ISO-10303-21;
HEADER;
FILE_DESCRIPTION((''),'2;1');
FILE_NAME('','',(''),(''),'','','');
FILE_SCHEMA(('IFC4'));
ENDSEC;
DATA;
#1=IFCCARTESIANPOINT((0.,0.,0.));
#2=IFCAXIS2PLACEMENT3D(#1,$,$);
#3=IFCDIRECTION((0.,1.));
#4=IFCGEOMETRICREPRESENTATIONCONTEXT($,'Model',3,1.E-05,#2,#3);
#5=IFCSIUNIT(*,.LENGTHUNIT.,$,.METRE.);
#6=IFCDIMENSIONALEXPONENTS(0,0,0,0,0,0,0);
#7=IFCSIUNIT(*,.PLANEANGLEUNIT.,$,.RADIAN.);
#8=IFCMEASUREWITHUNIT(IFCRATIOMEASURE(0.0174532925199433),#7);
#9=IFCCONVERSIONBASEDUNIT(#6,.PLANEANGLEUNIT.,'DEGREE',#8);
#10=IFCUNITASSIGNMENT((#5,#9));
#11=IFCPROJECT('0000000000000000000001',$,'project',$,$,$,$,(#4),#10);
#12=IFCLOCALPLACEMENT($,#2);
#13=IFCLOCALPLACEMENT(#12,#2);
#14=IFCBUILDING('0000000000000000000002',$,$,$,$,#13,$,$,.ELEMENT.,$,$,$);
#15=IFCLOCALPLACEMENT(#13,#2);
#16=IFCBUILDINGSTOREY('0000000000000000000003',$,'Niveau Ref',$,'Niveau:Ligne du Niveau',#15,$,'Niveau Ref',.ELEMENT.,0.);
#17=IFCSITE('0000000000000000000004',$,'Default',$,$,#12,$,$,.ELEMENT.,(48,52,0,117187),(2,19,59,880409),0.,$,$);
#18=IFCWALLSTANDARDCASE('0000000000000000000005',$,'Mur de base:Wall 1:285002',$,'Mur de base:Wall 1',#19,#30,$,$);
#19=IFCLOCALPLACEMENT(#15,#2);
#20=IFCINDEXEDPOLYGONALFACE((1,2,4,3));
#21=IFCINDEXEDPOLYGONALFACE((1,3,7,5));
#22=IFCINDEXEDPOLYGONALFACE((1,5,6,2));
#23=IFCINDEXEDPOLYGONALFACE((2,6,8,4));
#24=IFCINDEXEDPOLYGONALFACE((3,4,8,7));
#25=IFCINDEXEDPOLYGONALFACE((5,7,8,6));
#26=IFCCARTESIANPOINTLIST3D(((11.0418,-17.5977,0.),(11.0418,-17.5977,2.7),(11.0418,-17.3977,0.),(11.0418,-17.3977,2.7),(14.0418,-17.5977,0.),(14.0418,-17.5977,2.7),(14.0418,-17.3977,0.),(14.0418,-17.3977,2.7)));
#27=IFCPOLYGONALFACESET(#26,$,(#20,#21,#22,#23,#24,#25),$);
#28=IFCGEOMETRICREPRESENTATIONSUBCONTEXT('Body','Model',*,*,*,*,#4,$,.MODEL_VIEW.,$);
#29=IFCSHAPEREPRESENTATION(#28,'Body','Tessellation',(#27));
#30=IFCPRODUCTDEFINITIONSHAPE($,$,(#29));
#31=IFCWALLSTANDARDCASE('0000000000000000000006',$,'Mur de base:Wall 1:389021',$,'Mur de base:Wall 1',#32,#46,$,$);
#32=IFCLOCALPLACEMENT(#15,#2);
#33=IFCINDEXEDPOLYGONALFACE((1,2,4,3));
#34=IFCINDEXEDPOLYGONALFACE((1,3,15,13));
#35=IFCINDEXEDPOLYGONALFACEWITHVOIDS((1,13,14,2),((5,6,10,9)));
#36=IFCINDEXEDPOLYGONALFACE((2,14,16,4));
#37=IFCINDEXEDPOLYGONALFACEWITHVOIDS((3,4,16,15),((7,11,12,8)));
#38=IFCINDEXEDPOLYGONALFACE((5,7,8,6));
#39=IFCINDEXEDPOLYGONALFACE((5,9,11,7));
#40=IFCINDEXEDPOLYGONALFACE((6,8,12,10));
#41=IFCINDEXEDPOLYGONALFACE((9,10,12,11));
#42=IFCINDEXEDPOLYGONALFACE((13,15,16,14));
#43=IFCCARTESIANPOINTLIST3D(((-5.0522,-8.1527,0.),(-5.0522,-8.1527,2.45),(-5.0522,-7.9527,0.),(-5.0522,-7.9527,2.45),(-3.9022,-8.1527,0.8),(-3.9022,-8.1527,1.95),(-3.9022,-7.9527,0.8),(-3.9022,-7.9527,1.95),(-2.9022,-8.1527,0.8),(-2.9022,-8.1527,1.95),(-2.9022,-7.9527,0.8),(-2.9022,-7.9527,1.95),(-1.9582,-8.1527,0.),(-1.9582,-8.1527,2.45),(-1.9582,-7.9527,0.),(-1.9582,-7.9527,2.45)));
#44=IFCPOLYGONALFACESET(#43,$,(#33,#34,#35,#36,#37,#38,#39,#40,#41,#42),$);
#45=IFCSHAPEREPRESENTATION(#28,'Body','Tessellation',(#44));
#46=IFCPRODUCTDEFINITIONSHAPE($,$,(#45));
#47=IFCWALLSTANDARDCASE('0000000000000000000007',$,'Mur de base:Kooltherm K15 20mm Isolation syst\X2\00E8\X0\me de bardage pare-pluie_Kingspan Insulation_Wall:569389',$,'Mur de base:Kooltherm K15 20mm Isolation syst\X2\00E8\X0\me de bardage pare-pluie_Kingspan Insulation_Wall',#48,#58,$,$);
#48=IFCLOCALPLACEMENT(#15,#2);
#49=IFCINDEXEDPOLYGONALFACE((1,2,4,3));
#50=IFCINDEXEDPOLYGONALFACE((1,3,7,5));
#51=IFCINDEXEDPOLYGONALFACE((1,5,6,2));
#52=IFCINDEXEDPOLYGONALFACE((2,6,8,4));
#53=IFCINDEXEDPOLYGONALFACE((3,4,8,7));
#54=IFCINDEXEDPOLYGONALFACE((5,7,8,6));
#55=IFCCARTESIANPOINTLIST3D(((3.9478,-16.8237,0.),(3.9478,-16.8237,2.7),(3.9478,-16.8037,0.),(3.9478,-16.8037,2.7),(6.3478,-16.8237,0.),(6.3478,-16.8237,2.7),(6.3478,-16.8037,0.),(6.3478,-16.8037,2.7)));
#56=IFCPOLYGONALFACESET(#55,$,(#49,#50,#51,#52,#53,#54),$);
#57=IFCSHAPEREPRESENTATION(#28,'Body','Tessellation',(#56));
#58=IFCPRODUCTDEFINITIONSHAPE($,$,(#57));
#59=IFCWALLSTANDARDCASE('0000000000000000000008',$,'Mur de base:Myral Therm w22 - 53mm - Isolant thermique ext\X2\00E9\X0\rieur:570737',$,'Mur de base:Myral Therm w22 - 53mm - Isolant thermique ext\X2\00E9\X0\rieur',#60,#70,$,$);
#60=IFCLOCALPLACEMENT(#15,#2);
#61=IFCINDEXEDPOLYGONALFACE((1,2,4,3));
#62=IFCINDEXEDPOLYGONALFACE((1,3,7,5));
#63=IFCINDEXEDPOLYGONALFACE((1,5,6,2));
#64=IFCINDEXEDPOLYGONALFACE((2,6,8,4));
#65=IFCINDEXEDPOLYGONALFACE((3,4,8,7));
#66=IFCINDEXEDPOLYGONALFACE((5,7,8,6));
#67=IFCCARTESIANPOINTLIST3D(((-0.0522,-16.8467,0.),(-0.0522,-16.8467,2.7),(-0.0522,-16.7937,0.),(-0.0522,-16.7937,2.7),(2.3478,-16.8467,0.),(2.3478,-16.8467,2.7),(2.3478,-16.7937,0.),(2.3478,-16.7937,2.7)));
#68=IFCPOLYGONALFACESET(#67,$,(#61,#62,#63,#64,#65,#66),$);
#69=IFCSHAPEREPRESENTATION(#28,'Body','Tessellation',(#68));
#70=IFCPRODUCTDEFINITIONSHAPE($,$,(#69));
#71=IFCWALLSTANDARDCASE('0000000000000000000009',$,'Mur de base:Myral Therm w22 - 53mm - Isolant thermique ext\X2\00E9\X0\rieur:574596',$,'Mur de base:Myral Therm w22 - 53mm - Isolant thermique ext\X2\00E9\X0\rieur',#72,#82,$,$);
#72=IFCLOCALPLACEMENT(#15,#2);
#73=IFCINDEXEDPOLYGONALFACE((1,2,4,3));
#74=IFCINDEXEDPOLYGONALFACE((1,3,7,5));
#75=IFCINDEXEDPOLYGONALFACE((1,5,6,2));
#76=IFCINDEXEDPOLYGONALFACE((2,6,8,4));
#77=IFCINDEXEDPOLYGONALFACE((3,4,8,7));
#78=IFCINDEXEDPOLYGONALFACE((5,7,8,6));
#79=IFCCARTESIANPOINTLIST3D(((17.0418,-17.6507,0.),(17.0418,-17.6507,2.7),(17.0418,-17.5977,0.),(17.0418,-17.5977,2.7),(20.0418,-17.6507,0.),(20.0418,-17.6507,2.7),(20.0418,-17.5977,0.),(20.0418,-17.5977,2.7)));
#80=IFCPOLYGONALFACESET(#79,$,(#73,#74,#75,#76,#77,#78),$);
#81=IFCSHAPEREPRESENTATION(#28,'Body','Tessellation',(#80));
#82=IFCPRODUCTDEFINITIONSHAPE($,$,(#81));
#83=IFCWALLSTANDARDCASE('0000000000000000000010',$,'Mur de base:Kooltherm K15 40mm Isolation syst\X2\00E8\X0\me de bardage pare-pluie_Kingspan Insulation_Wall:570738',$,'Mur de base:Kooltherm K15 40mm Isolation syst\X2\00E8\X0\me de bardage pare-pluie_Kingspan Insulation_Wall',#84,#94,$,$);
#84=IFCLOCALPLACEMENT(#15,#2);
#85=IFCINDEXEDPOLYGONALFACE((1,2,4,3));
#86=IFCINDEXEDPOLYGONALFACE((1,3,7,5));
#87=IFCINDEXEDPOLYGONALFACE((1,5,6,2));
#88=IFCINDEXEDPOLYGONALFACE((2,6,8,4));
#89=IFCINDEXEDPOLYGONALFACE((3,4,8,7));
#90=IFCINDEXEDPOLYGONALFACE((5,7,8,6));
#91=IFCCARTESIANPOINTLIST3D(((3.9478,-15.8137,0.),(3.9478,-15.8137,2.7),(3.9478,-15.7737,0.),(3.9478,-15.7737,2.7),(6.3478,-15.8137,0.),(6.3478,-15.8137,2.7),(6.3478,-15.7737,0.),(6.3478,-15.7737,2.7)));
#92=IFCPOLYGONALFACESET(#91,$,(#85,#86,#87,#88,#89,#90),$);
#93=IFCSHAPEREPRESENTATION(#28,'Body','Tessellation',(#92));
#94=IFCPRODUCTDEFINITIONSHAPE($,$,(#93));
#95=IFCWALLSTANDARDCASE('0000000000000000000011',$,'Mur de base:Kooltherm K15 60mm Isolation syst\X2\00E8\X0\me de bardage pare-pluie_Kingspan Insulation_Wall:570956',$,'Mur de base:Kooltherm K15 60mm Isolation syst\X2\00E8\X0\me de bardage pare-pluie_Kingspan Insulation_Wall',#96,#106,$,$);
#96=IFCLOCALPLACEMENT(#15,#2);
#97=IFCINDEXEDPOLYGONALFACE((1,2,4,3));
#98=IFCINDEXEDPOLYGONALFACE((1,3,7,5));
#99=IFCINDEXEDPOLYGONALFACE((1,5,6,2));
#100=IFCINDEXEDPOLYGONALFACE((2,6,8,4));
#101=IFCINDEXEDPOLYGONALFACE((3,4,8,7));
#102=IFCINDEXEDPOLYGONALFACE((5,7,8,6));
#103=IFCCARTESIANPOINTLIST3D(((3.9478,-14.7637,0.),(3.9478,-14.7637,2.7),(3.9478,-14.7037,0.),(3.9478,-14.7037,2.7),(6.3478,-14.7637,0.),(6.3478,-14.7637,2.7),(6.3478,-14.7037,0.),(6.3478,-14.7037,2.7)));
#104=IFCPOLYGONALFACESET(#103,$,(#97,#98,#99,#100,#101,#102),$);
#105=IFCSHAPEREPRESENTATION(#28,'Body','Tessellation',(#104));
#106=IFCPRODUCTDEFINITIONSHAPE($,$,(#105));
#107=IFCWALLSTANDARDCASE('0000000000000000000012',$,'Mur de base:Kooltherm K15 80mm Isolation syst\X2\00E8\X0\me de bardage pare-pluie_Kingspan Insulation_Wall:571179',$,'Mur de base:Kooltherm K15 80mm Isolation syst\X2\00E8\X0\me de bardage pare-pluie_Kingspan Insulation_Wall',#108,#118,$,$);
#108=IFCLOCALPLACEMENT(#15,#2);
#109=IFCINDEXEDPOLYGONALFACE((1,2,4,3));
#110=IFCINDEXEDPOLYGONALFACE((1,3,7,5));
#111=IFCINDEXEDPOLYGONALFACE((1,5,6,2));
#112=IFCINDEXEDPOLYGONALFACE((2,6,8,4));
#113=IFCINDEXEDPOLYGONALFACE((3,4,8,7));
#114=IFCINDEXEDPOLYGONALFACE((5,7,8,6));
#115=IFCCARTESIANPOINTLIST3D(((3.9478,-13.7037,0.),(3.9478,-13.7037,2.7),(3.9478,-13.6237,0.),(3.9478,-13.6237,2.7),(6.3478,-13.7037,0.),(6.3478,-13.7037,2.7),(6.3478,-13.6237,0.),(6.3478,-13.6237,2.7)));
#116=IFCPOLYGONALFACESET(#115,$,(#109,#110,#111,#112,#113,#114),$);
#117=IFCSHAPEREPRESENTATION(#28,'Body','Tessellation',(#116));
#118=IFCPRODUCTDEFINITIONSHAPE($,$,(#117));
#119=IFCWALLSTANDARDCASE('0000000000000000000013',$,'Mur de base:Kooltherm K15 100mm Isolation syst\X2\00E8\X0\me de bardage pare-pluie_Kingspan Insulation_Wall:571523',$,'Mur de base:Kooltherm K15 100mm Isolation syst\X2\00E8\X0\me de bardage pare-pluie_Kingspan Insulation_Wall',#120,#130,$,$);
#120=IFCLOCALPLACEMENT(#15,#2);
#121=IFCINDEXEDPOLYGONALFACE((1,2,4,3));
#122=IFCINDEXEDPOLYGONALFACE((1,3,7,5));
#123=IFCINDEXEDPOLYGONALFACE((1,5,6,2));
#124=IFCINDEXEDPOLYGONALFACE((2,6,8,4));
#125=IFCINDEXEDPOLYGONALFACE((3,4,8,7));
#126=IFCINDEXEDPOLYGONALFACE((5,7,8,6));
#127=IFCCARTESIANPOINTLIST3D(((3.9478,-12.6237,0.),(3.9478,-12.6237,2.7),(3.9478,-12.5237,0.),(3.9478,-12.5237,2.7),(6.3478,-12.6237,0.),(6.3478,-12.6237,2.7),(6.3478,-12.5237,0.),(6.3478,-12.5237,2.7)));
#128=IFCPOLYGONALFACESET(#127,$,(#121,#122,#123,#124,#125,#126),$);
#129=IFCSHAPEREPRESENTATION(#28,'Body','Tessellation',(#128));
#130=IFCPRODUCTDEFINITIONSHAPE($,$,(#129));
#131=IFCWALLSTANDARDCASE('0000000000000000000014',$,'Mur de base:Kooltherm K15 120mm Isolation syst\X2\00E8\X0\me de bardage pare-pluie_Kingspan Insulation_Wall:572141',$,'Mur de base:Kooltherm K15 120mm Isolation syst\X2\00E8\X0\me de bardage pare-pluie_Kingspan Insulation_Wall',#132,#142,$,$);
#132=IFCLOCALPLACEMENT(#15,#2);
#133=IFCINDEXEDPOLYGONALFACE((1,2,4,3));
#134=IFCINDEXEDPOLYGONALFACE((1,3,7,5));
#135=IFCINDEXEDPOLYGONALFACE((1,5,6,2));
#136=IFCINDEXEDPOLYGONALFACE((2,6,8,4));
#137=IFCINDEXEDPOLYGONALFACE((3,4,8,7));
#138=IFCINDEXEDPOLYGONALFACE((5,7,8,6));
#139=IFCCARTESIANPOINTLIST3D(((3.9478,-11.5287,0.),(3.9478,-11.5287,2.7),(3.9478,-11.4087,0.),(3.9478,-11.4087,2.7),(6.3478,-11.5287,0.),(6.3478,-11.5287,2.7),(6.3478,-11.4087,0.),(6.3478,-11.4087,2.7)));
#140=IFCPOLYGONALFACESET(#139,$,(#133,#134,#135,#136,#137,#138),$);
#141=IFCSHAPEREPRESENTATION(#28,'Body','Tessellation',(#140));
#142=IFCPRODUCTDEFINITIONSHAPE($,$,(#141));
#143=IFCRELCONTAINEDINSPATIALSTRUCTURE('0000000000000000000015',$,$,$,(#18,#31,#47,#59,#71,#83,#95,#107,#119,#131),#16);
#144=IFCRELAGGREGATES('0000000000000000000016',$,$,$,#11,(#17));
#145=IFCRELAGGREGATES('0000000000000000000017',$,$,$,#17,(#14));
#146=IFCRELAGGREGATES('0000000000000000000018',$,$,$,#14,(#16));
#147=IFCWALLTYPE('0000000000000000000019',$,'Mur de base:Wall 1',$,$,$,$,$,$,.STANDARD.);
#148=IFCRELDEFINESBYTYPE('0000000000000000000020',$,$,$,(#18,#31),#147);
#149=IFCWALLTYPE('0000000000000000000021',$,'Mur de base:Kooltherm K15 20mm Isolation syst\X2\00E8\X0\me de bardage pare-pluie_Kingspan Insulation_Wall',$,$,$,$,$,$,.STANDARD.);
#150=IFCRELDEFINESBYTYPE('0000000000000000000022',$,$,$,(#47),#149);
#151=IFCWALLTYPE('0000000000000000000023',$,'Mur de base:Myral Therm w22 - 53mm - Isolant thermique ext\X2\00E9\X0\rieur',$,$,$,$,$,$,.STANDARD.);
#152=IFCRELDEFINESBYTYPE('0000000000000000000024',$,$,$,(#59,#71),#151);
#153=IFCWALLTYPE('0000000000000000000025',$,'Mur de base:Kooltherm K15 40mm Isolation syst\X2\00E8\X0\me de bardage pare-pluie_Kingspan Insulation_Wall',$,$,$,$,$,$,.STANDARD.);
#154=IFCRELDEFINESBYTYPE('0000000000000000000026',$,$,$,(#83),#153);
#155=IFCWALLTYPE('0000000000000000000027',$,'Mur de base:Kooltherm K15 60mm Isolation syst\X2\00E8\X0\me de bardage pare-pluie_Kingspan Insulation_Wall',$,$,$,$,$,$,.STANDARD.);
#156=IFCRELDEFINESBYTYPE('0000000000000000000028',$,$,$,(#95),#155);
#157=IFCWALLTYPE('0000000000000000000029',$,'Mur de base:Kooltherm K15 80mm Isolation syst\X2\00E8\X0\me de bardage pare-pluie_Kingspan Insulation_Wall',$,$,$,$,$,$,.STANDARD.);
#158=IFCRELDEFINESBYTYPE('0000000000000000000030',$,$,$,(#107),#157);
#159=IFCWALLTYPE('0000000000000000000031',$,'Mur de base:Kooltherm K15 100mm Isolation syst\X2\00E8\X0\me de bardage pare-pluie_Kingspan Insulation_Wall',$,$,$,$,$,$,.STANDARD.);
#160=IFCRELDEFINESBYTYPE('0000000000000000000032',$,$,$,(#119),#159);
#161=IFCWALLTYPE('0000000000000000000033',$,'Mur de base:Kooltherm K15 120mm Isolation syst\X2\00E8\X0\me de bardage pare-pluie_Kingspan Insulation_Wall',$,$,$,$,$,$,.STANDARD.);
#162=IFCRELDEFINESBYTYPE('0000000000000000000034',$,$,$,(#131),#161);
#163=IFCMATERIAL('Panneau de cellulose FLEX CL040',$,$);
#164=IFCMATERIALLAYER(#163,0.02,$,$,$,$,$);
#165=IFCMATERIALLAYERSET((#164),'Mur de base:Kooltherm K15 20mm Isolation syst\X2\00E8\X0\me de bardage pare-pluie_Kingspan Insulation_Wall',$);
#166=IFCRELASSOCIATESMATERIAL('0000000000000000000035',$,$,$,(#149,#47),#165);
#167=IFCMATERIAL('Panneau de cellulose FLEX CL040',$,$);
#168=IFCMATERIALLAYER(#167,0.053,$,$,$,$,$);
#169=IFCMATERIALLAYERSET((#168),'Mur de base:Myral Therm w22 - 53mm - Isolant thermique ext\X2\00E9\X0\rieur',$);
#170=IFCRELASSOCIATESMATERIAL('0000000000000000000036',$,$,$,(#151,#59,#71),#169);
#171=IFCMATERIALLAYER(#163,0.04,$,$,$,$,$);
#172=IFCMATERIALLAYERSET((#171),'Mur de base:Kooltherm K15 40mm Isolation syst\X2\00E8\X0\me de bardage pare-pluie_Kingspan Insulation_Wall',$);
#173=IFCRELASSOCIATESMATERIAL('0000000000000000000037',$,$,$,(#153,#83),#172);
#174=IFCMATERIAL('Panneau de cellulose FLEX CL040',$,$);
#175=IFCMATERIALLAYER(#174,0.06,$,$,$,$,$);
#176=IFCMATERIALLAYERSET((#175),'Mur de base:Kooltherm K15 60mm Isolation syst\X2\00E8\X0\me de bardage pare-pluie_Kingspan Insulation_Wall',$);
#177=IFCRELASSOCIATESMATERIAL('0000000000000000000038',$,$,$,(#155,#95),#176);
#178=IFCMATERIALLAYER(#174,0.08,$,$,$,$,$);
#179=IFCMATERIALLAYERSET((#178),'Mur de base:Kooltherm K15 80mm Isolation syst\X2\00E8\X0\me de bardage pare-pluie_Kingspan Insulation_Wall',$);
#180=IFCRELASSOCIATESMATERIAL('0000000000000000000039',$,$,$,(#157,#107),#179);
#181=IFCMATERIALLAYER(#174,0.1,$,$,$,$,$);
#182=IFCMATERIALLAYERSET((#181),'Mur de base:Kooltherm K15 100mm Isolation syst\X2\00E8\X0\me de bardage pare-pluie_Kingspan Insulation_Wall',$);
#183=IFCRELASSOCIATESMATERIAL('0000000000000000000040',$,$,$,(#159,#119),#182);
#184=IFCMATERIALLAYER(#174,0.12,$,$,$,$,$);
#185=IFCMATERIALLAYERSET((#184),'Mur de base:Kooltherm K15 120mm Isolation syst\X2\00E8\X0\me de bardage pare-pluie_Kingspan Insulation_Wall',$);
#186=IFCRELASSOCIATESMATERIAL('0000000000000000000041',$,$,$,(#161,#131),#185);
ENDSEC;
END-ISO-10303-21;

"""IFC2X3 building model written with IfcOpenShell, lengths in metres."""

from ifc_helpers import new_model, entity, si_unit, converted_unit, direction, frame, frame_2d, origin, place, context, subcontext, project, spatial, rectangle, extrude, material, layer, layer_set, layer_usage, type_object, element, save


model = new_model("IFC2X3")

# Units and contexts
model_context = context("Model", 3, precision=1e-05, world=origin(), true_north=direction((0.0, 1.0)))
body_context = subcontext(model_context, "Body", "Model", "MODEL_VIEW")
ifc_project = project(units=[si_unit("LENGTHUNIT", "METRE"), converted_unit("PLANEANGLEUNIT", "DEGREE", entity("IfcRatioMeasure", 0.0174532925199433), si_unit("PLANEANGLEUNIT", "RADIAN"), dimensions=[0, 0, 0, 0, 0, 0, 0])], contexts=[model_context])

# Site, building, storey
site_placement = place(None, origin())
site = spatial("IfcSite", under=ifc_project, at=site_placement, Name="Default", CompositionType="ELEMENT", RefLatitude=(48, 52, 0, 117187), RefLongitude=(2, 19, 59, 880409), RefElevation=0.0)
building_placement = place(site_placement, origin())
building = spatial("IfcBuilding", under=site, at=building_placement, CompositionType="ELEMENT")
storey_placement = place(building_placement, origin())
storey = spatial("IfcBuildingStorey", under=building, at=storey_placement, Name="Niveau Ref", ObjectType="Niveau:Ligne du Niveau", LongName="Niveau Ref", CompositionType="ELEMENT", Elevation=0.0)

# Wall
wall_type_1 = type_object("IfcWallType", Name="Mur de base:Wall 1", PredefinedType="STANDARD")
for number, where, name in (
    (1, (11.0418, -17.4977, 0.0), "Mur de base:Wall 1:285002"),
):
    element("IfcWallStandardCase", number, at=place(storey_placement, frame(where)), inside=storey, type_object=wall_type_1, Name=name, ObjectType="Mur de base:Wall 1", context=body_context, shape_type="SweptSolid", body=[
        extrude(rectangle(XDim=3.0, YDim=0.2, at=frame_2d((1.5, 0.0), x_axis=(-1.0, 0.0))), origin(), (0.0, 0.0, 1.0), 2.7),
    ])

# Wall, opening
wall_1_placement = place(storey_placement, frame((-1.9582, -8.0527, 0.0), z_axis=(0.0, 0.0, 1.0), x_axis=(-1.0, 0.0, 0.0)))
wall_1 = element("IfcWallStandardCase", 2, at=wall_1_placement, inside=storey, type_object=wall_type_1, Name="Mur de base:Wall 1:389021", ObjectType="Mur de base:Wall 1", context=body_context, shape_type="SweptSolid", body=[
    extrude(rectangle(XDim=3.094, YDim=0.2, at=frame_2d((1.547, 0.0), x_axis=(-1.0, 0.0))), origin(), (0.0, 0.0, 1.0), 2.45),
])
opening_placement = place(wall_1_placement, frame((0.944, -0.1, 0.8)))
element("IfcOpeningElement", 3, at=opening_placement, cuts=wall_1, ObjectType="Opening", context=body_context, shape_type="SweptSolid", body=[
    extrude(rectangle(XDim=1.15, YDim=1.0, at=frame_2d((0.575, 0.5), x_axis=(1.0, 0.0))), frame((0.0, 0.0, 0.0), z_axis=(0.0, 1.0, 0.0), x_axis=(0.0, 0.0, 1.0)), (0.0, 0.0, 1.0), 0.2),
])

# Walls
ifc_material_1 = material(Name="Panneau de cellulose FLEX CL040")
ifc_layer_1 = layer(ifc_material_1, 0.02)
ifc_layer_set_1 = layer_set([ifc_layer_1], Name="Mur de base:Kooltherm K15 20mm Isolation système de bardage pare-pluie_Kingspan Insulation_Wall")
ifc_layer_usage_1 = layer_usage(ifc_layer_set_1, "AXIS2", "NEGATIVE", 0.01)
wall_type_2 = type_object("IfcWallType", Name="Mur de base:Kooltherm K15 20mm Isolation système de bardage pare-pluie_Kingspan Insulation_Wall", PredefinedType="STANDARD", material=ifc_layer_set_1)
wall_2_placement = place(storey_placement, frame((3.9478, -16.8137, 0.0)))
element("IfcWallStandardCase", 4, at=wall_2_placement, inside=storey, type_object=wall_type_2, material=ifc_layer_usage_1, Name="Mur de base:Kooltherm K15 20mm Isolation système de bardage pare-pluie_Kingspan Insulation_Wall:569389", ObjectType="Mur de base:Kooltherm K15 20mm Isolation système de bardage pare-pluie_Kingspan Insulation_Wall", context=body_context, shape_type="SweptSolid", body=[
    extrude(rectangle(XDim=2.4, YDim=0.02, at=frame_2d((1.2, 0.0), x_axis=(-1.0, 0.0))), origin(), (0.0, 0.0, 1.0), 2.7),
])
ifc_material_2 = material(Name="Panneau de cellulose FLEX CL040")
ifc_layer_2 = layer(ifc_material_2, 0.053)
ifc_layer_set_2 = layer_set([ifc_layer_2], Name="Mur de base:Myral Therm w22 - 53mm - Isolant thermique extérieur")
ifc_layer_usage_2 = layer_usage(ifc_layer_set_2, "AXIS2", "NEGATIVE", 0.0265)
wall_type_3 = type_object("IfcWallType", Name="Mur de base:Myral Therm w22 - 53mm - Isolant thermique extérieur", PredefinedType="STANDARD", material=ifc_layer_set_2)
wall_3_placement = place(storey_placement, frame((-0.0522, -16.8202, 0.0)))
element("IfcWallStandardCase", 5, at=wall_3_placement, inside=storey, type_object=wall_type_3, material=ifc_layer_usage_2, Name="Mur de base:Myral Therm w22 - 53mm - Isolant thermique extérieur:570737", ObjectType="Mur de base:Myral Therm w22 - 53mm - Isolant thermique extérieur", context=body_context, shape_type="SweptSolid", body=[
    extrude(rectangle(XDim=2.4, YDim=0.053, at=frame_2d((1.2, 0.0), x_axis=(-1.0, 0.0))), origin(), (0.0, 0.0, 1.0), 2.7),
])
ifc_layer_usage_3 = layer_usage(ifc_layer_set_2, "AXIS2", "NEGATIVE", 0.0265)
wall_4_placement = place(storey_placement, frame((17.0418, -17.6242, 0.0)))
element("IfcWallStandardCase", 6, at=wall_4_placement, inside=storey, type_object=wall_type_3, material=ifc_layer_usage_3, Name="Mur de base:Myral Therm w22 - 53mm - Isolant thermique extérieur:574596", ObjectType="Mur de base:Myral Therm w22 - 53mm - Isolant thermique extérieur", context=body_context, shape_type="SweptSolid", body=[
    extrude(rectangle(XDim=3.0, YDim=0.053, at=frame_2d((1.5, 0.0), x_axis=(-1.0, 0.0))), origin(), (0.0, 0.0, 1.0), 2.7),
])
ifc_layer_3 = layer(ifc_material_1, 0.04)
ifc_layer_set_3 = layer_set([ifc_layer_3], Name="Mur de base:Kooltherm K15 40mm Isolation système de bardage pare-pluie_Kingspan Insulation_Wall")
ifc_layer_usage_4 = layer_usage(ifc_layer_set_3, "AXIS2", "NEGATIVE", 0.02)
wall_type_4 = type_object("IfcWallType", Name="Mur de base:Kooltherm K15 40mm Isolation système de bardage pare-pluie_Kingspan Insulation_Wall", PredefinedType="STANDARD", material=ifc_layer_set_3)
wall_5_placement = place(storey_placement, frame((3.9478, -15.7937, 0.0)))
element("IfcWallStandardCase", 7, at=wall_5_placement, inside=storey, type_object=wall_type_4, material=ifc_layer_usage_4, Name="Mur de base:Kooltherm K15 40mm Isolation système de bardage pare-pluie_Kingspan Insulation_Wall:570738", ObjectType="Mur de base:Kooltherm K15 40mm Isolation système de bardage pare-pluie_Kingspan Insulation_Wall", context=body_context, shape_type="SweptSolid", body=[
    extrude(rectangle(XDim=2.4, YDim=0.04, at=frame_2d((1.2, 0.0), x_axis=(-1.0, 0.0))), origin(), (0.0, 0.0, 1.0), 2.7),
])
ifc_material_3 = material(Name="Panneau de cellulose FLEX CL040")
ifc_layer_4 = layer(ifc_material_3, 0.06)
ifc_layer_set_4 = layer_set([ifc_layer_4], Name="Mur de base:Kooltherm K15 60mm Isolation système de bardage pare-pluie_Kingspan Insulation_Wall")
ifc_layer_usage_5 = layer_usage(ifc_layer_set_4, "AXIS2", "NEGATIVE", 0.03)
wall_type_5 = type_object("IfcWallType", Name="Mur de base:Kooltherm K15 60mm Isolation système de bardage pare-pluie_Kingspan Insulation_Wall", PredefinedType="STANDARD", material=ifc_layer_set_4)
wall_6_placement = place(storey_placement, frame((3.9478, -14.7337, 0.0)))
element("IfcWallStandardCase", 8, at=wall_6_placement, inside=storey, type_object=wall_type_5, material=ifc_layer_usage_5, Name="Mur de base:Kooltherm K15 60mm Isolation système de bardage pare-pluie_Kingspan Insulation_Wall:570956", ObjectType="Mur de base:Kooltherm K15 60mm Isolation système de bardage pare-pluie_Kingspan Insulation_Wall", context=body_context, shape_type="SweptSolid", body=[
    extrude(rectangle(XDim=2.4, YDim=0.06, at=frame_2d((1.2, 0.0), x_axis=(-1.0, 0.0))), origin(), (0.0, 0.0, 1.0), 2.7),
])
ifc_layer_5 = layer(ifc_material_3, 0.08)
ifc_layer_set_5 = layer_set([ifc_layer_5], Name="Mur de base:Kooltherm K15 80mm Isolation système de bardage pare-pluie_Kingspan Insulation_Wall")
ifc_layer_usage_6 = layer_usage(ifc_layer_set_5, "AXIS2", "NEGATIVE", 0.04)
wall_type_6 = type_object("IfcWallType", Name="Mur de base:Kooltherm K15 80mm Isolation système de bardage pare-pluie_Kingspan Insulation_Wall", PredefinedType="STANDARD", material=ifc_layer_set_5)
wall_7_placement = place(storey_placement, frame((3.9478, -13.6637, 0.0)))
element("IfcWallStandardCase", 9, at=wall_7_placement, inside=storey, type_object=wall_type_6, material=ifc_layer_usage_6, Name="Mur de base:Kooltherm K15 80mm Isolation système de bardage pare-pluie_Kingspan Insulation_Wall:571179", ObjectType="Mur de base:Kooltherm K15 80mm Isolation système de bardage pare-pluie_Kingspan Insulation_Wall", context=body_context, shape_type="SweptSolid", body=[
    extrude(rectangle(XDim=2.4, YDim=0.08, at=frame_2d((1.2, 0.0), x_axis=(-1.0, 0.0))), origin(), (0.0, 0.0, 1.0), 2.7),
])
ifc_layer_6 = layer(ifc_material_3, 0.1)
ifc_layer_set_6 = layer_set([ifc_layer_6], Name="Mur de base:Kooltherm K15 100mm Isolation système de bardage pare-pluie_Kingspan Insulation_Wall")
ifc_layer_usage_7 = layer_usage(ifc_layer_set_6, "AXIS2", "NEGATIVE", 0.05)
wall_type_7 = type_object("IfcWallType", Name="Mur de base:Kooltherm K15 100mm Isolation système de bardage pare-pluie_Kingspan Insulation_Wall", PredefinedType="STANDARD", material=ifc_layer_set_6)
wall_8_placement = place(storey_placement, frame((3.9478, -12.5737, 0.0)))
element("IfcWallStandardCase", 10, at=wall_8_placement, inside=storey, type_object=wall_type_7, material=ifc_layer_usage_7, Name="Mur de base:Kooltherm K15 100mm Isolation système de bardage pare-pluie_Kingspan Insulation_Wall:571523", ObjectType="Mur de base:Kooltherm K15 100mm Isolation système de bardage pare-pluie_Kingspan Insulation_Wall", context=body_context, shape_type="SweptSolid", body=[
    extrude(rectangle(XDim=2.4, YDim=0.1, at=frame_2d((1.2, 0.0), x_axis=(-1.0, 0.0))), origin(), (0.0, 0.0, 1.0), 2.7),
])
ifc_layer_7 = layer(ifc_material_3, 0.12)
ifc_layer_set_7 = layer_set([ifc_layer_7], Name="Mur de base:Kooltherm K15 120mm Isolation système de bardage pare-pluie_Kingspan Insulation_Wall")
ifc_layer_usage_8 = layer_usage(ifc_layer_set_7, "AXIS2", "NEGATIVE", 0.06)
wall_type_8 = type_object("IfcWallType", Name="Mur de base:Kooltherm K15 120mm Isolation système de bardage pare-pluie_Kingspan Insulation_Wall", PredefinedType="STANDARD", material=ifc_layer_set_7)
wall_9_placement = place(storey_placement, frame((3.9478, -11.4687, 0.0)))
element("IfcWallStandardCase", 11, at=wall_9_placement, inside=storey, type_object=wall_type_8, material=ifc_layer_usage_8, Name="Mur de base:Kooltherm K15 120mm Isolation système de bardage pare-pluie_Kingspan Insulation_Wall:572141", ObjectType="Mur de base:Kooltherm K15 120mm Isolation système de bardage pare-pluie_Kingspan Insulation_Wall", context=body_context, shape_type="SweptSolid", body=[
    extrude(rectangle(XDim=2.4, YDim=0.12, at=frame_2d((1.2, 0.0), x_axis=(-1.0, 0.0))), origin(), (0.0, 0.0, 1.0), 2.7),
])

save(model, "model.ifc")
